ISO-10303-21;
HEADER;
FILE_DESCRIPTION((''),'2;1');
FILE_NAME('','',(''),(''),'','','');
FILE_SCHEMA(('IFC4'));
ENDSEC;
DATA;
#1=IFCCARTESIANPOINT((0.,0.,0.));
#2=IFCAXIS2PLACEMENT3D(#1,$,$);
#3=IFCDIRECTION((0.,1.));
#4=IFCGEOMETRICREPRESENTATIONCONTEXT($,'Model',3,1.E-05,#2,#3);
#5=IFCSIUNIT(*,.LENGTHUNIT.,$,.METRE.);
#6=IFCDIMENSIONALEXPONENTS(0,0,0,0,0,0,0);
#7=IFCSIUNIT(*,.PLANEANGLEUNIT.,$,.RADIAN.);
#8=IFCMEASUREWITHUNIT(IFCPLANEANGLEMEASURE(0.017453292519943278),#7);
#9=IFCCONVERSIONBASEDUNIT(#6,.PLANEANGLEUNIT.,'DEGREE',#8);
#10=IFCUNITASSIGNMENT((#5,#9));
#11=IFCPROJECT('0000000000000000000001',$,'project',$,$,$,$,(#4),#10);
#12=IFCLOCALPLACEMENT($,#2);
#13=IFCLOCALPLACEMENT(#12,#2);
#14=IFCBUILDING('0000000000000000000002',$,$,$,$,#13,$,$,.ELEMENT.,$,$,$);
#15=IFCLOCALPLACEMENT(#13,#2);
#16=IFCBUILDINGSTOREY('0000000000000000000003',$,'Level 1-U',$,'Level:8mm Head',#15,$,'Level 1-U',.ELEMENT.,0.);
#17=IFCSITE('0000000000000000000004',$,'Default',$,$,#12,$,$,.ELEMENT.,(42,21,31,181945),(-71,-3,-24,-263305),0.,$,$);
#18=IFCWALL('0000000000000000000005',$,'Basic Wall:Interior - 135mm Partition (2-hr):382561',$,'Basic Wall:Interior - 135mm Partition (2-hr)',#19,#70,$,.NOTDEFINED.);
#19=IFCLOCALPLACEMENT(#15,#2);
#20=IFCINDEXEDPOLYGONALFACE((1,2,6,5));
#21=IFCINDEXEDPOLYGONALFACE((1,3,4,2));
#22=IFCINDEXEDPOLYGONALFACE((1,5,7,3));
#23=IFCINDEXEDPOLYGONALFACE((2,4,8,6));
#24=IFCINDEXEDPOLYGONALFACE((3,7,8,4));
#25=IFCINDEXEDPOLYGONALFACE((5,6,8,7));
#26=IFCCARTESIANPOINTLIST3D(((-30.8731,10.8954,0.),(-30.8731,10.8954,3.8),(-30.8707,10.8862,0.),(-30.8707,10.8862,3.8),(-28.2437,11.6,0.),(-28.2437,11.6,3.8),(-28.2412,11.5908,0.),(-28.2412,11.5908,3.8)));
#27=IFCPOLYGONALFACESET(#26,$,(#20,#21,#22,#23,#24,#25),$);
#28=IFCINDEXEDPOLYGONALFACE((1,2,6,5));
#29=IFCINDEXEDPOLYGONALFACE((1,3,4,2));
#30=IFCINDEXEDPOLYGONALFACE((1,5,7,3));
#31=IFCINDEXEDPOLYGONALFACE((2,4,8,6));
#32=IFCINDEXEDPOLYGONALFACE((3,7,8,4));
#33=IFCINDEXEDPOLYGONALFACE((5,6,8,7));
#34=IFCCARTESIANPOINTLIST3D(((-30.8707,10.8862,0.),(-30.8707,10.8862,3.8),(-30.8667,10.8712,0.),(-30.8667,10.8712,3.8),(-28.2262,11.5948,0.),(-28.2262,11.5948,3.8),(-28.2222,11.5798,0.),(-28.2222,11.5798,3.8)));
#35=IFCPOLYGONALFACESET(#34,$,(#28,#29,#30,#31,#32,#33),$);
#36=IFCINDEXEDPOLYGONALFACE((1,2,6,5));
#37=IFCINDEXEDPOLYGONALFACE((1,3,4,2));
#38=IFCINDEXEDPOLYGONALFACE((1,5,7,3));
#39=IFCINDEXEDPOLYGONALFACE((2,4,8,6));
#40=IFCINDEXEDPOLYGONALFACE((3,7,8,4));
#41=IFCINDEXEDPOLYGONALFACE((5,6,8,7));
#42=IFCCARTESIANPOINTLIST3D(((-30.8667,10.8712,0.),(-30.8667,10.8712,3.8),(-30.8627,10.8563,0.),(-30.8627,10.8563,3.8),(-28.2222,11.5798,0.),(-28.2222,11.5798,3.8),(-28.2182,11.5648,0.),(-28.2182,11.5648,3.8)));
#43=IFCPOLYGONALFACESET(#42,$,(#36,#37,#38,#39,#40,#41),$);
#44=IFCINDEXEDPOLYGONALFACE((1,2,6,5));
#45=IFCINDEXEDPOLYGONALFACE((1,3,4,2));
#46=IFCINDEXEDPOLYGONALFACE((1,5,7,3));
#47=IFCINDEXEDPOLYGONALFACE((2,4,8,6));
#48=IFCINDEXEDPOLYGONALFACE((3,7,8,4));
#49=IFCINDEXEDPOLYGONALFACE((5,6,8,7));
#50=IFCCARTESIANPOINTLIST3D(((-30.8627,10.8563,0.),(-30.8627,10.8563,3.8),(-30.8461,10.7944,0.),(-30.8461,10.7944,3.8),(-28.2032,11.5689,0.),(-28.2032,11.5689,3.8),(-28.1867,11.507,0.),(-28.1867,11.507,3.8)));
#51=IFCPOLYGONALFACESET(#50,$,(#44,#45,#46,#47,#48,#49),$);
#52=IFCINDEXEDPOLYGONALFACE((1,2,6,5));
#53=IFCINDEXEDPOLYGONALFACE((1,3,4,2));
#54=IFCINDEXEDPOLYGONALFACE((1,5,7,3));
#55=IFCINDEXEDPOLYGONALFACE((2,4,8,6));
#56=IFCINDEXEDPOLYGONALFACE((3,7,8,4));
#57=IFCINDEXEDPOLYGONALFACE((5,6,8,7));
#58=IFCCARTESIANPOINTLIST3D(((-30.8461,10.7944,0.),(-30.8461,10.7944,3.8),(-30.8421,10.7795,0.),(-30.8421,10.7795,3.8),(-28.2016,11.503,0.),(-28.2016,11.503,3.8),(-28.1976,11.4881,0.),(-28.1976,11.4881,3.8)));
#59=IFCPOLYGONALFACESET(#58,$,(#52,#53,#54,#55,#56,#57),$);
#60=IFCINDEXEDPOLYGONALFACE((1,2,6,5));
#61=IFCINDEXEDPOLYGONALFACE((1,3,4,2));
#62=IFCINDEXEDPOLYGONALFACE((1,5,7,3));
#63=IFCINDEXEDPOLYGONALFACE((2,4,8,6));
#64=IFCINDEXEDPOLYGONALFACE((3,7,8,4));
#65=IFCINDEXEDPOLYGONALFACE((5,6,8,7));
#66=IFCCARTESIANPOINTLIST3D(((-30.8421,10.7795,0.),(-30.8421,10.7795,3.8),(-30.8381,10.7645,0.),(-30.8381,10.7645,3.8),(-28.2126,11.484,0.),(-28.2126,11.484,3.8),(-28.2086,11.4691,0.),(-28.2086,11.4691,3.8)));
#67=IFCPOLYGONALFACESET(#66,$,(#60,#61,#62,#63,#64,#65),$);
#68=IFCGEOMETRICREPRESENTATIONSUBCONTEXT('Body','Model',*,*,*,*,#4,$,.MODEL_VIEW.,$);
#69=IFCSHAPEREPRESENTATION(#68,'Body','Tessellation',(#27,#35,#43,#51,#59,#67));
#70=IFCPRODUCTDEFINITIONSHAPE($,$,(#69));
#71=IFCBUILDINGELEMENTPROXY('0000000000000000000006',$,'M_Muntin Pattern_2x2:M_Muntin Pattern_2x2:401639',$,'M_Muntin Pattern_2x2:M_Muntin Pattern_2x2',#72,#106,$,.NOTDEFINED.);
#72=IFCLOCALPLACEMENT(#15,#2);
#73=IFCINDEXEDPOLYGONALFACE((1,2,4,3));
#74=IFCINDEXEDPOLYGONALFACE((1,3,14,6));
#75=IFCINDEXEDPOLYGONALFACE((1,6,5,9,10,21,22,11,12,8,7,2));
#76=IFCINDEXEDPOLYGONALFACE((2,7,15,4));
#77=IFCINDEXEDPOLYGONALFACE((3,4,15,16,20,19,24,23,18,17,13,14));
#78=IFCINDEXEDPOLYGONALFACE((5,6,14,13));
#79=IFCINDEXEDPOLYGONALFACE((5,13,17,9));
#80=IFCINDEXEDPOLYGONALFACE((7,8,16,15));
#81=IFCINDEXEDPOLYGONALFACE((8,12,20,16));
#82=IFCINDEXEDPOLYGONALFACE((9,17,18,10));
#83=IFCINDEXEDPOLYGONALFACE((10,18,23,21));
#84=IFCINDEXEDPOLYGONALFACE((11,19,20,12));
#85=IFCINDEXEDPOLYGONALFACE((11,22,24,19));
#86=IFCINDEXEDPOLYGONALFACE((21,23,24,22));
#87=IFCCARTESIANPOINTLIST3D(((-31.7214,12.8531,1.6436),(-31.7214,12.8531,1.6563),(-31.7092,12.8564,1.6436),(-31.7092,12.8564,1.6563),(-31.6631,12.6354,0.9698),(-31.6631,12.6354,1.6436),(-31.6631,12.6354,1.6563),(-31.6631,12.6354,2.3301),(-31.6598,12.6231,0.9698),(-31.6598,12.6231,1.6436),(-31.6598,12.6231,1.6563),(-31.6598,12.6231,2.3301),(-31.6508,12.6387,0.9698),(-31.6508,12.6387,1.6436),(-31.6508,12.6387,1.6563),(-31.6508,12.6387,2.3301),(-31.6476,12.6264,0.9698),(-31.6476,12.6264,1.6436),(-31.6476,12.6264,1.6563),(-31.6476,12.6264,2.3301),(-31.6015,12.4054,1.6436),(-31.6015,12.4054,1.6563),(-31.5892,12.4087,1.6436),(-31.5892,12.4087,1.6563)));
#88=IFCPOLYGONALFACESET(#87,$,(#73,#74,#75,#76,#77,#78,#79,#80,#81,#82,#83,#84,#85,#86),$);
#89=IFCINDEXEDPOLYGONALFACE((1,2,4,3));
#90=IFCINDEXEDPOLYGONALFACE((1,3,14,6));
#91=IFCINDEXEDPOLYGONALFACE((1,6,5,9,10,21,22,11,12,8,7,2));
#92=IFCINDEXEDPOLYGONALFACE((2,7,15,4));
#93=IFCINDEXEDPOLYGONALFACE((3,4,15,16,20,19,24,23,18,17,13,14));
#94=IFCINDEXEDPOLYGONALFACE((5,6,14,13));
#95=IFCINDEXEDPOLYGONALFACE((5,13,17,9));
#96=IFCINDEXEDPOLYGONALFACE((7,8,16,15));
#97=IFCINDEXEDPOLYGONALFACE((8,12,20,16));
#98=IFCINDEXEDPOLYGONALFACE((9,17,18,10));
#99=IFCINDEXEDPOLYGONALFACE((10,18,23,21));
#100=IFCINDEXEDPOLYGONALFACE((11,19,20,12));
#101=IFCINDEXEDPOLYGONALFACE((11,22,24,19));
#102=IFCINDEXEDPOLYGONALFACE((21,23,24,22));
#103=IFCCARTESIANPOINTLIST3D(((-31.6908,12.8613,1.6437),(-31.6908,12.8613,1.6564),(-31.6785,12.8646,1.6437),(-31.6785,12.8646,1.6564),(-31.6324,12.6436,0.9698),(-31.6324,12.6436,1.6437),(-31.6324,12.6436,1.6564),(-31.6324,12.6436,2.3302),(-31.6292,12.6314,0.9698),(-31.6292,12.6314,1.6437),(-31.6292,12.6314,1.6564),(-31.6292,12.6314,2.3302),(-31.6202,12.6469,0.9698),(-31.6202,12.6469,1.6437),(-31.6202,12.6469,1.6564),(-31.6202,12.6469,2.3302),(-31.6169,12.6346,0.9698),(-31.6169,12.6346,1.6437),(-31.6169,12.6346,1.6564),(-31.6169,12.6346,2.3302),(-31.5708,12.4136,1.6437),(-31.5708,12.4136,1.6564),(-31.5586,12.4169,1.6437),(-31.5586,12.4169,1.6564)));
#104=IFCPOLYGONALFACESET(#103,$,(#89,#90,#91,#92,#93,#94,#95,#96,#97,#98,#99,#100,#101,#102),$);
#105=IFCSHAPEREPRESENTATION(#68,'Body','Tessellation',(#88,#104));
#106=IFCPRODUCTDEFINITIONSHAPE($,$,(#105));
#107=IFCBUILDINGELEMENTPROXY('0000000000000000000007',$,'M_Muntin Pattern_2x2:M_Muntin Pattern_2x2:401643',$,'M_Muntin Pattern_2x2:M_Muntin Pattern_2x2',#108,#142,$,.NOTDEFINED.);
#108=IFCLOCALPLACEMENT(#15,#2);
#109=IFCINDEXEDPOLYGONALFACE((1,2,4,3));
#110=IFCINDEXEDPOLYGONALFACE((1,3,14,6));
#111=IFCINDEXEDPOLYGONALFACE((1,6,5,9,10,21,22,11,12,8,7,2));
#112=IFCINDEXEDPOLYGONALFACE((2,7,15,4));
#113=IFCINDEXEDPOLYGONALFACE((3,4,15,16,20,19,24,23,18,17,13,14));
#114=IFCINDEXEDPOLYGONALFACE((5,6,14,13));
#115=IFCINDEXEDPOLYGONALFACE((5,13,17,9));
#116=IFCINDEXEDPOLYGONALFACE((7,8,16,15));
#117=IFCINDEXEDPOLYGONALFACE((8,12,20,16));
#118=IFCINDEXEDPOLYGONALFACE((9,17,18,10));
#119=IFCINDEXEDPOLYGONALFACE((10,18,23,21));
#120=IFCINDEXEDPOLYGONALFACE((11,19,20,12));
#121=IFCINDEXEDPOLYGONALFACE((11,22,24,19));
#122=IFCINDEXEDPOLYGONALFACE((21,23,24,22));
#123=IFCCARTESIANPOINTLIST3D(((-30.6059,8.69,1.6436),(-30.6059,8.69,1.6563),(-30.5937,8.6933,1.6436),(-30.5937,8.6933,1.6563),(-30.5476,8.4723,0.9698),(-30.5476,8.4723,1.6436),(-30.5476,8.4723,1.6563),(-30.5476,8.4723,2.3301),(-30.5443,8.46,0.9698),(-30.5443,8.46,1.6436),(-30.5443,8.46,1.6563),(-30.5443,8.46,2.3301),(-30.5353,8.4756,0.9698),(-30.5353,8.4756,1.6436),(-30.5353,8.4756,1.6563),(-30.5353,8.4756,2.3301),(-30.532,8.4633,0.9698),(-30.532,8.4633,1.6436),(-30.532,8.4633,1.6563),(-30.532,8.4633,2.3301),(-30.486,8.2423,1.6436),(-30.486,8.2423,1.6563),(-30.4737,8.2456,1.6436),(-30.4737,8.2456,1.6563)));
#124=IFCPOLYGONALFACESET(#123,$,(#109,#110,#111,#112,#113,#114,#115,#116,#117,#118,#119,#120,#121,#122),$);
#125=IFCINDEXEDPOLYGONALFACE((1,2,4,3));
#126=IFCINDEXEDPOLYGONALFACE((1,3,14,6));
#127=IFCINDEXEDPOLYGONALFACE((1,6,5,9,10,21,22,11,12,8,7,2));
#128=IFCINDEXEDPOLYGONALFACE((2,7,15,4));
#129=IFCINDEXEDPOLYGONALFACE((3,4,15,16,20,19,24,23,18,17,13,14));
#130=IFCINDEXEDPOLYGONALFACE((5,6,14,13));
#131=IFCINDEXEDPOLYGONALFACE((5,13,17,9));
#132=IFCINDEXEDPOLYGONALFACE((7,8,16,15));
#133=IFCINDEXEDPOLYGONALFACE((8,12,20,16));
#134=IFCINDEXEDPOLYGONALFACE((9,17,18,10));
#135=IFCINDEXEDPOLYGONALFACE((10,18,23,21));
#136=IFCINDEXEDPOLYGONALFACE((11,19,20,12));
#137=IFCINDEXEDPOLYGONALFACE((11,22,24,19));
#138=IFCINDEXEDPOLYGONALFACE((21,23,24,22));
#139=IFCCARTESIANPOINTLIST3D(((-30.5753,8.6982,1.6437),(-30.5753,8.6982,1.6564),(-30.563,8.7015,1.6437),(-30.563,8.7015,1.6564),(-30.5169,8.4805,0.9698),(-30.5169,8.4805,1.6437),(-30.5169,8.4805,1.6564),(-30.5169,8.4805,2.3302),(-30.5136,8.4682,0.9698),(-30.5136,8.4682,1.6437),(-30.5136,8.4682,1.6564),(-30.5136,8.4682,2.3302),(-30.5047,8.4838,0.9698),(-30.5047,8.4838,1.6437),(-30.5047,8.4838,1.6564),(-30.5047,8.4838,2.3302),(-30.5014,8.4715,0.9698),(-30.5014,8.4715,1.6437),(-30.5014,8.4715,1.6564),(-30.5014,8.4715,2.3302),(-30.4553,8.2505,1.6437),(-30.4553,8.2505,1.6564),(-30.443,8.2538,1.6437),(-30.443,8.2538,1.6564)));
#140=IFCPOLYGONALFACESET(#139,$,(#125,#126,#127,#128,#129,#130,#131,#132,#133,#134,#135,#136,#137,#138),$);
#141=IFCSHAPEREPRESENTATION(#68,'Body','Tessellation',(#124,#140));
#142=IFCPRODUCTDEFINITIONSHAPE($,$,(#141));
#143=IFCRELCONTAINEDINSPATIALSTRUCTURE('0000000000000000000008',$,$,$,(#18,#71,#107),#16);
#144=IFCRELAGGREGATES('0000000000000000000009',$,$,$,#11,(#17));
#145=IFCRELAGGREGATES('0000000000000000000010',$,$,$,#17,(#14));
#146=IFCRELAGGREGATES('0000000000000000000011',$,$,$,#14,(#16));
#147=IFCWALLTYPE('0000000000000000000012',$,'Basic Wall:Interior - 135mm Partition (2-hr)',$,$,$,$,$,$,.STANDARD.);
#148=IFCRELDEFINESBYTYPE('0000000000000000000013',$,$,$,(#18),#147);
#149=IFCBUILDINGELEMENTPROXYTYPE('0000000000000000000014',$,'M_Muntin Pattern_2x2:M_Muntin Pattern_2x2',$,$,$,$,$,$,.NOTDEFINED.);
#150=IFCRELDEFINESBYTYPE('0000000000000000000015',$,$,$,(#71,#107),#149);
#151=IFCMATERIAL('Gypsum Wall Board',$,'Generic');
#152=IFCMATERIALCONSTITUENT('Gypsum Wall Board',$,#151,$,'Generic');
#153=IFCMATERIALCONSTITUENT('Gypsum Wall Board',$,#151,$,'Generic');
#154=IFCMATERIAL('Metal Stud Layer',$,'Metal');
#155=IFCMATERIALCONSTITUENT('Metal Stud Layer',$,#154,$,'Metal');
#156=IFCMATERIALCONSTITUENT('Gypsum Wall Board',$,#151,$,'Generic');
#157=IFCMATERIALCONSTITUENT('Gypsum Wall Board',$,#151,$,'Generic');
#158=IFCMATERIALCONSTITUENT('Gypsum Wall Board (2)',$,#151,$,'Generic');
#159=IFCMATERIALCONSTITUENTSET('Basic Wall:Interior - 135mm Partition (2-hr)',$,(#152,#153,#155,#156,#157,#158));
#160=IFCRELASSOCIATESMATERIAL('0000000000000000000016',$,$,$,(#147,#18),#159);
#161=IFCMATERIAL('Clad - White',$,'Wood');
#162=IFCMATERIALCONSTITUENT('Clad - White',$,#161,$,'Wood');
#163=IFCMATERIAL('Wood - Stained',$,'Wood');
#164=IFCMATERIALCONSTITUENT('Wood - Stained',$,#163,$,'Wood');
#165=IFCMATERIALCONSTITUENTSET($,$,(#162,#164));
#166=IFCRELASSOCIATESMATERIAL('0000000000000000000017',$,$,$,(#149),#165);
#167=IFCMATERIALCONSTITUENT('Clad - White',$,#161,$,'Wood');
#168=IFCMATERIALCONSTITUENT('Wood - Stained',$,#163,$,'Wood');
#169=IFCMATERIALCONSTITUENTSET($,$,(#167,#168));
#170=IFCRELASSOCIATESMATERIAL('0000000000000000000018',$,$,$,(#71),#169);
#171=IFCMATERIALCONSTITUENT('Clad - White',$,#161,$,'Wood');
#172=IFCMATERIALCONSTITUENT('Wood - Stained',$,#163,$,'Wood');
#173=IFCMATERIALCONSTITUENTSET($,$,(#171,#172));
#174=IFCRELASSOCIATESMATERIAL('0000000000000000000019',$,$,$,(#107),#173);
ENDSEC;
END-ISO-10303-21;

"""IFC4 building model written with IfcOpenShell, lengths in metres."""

from ifc_helpers import new_model, entity, si_unit, converted_unit, direction, frame, origin, place, context, subcontext, project, spatial, indexed_curve, outline, extrude, source, transform, mapped, material, constituent, constituent_set, type_object, type_shapes, element, save


model = new_model("IFC4")

# Units and contexts
model_context = context("Model", 3, precision=1e-05, world=origin(), true_north=direction((0.0, 1.0)))
body_context = subcontext(model_context, "Body", "Model", "MODEL_VIEW")
ifc_project = project(units=[si_unit("LENGTHUNIT", "METRE"), converted_unit("PLANEANGLEUNIT", "DEGREE", entity("IfcPlaneAngleMeasure", 0.017453292519943278), si_unit("PLANEANGLEUNIT", "RADIAN"), dimensions=[0, 0, 0, 0, 0, 0, 0])], contexts=[model_context])

# Site, building, storey
site_placement = place(None, origin())
site = spatial("IfcSite", under=ifc_project, at=site_placement, Name="Default", CompositionType="ELEMENT", RefLatitude=(42, 21, 31, 181945), RefLongitude=(-71, -3, -24, -263305), RefElevation=0.0)
building_placement = place(site_placement, origin())
building = spatial("IfcBuilding", under=site, at=building_placement, CompositionType="ELEMENT")
storey_placement = place(building_placement, origin())
storey = spatial("IfcBuildingStorey", under=building, at=storey_placement, Name="Level 1-U", ObjectType="Level:8mm Head", LongName="Level 1-U", CompositionType="ELEMENT", Elevation=0.0)

# Shared definitions
ifc_material_1 = material(Name="Gypsum Wall Board", Category="Generic")
ifc_constituent_1 = constituent(ifc_material_1, Name="Gypsum Wall Board", Category="Generic")
ifc_constituent_2 = constituent(ifc_material_1, Name="Gypsum Wall Board", Category="Generic")
ifc_material_2 = material(Name="Metal Stud Layer", Category="Metal")
ifc_constituent_3 = constituent(ifc_material_2, Name="Metal Stud Layer", Category="Metal")
ifc_constituent_4 = constituent(ifc_material_1, Name="Gypsum Wall Board", Category="Generic")
ifc_constituent_5 = constituent(ifc_material_1, Name="Gypsum Wall Board", Category="Generic")
ifc_constituent_6 = constituent(ifc_material_1, Name="Gypsum Wall Board (2)", Category="Generic")
ifc_constituent_set_1 = constituent_set(constituents=[ifc_constituent_1, ifc_constituent_2, ifc_constituent_3, ifc_constituent_4, ifc_constituent_5, ifc_constituent_6], Name="Basic Wall:Interior - 135mm Partition (2-hr)")
wall_type = type_object("IfcWallType", Name="Basic Wall:Interior - 135mm Partition (2-hr)", PredefinedType="STANDARD", material=ifc_constituent_set_1)

# Wall
wall_1_placement = place(storey_placement, frame((-28.2261, 11.5345, 0.0), z_axis=(0.0, 0.0, 1.0), x_axis=(-0.965926, -0.258819, 0.0)))
element("IfcWall", 1, at=wall_1_placement, inside=storey, type_object=wall_type, material=ifc_constituent_set_1, Name="Basic Wall:Interior - 135mm Partition (2-hr):382561", ObjectType="Basic Wall:Interior - 135mm Partition (2-hr)", PredefinedType="NOTDEFINED", context=body_context, shape_type="SweptSolid", body=[
    extrude(outline(indexed_curve([(-0.0047, -1.3611), (0.0048, -1.3611), (0.0047, 1.3611), (-0.0048, 1.3611), (-0.0047, -1.3611)], self_intersect=False)), frame((1.3611, -0.063, 0.0), z_axis=(0.0, 0.0, 1.0), x_axis=(0.0, 1.0, 0.0)), (0.0, 0.0, 1.0), 3.8),
    extrude(outline(indexed_curve([(-1.3689, -0.0077), (1.3689, -0.0078), (1.3689, 0.0077), (-1.3689, 0.0078), (-1.3689, -0.0077)], self_intersect=False)), frame((1.3534, -0.0505, 0.0)), (0.0, 0.0, 1.0), 3.8),
    extrude(outline(indexed_curve([(-1.3689, -0.0077), (1.3689, -0.0078), (1.3689, 0.0077), (-1.3689, 0.0078), (-1.3689, -0.0077)], self_intersect=False)), frame((1.3534, -0.035, 0.0)), (0.0, 0.0, 1.0), 3.8),
    extrude(outline(indexed_curve([(-1.3766, -0.032), (1.3766, -0.032), (1.3766, 0.032), (-1.3766, 0.032), (-1.3766, -0.032)], self_intersect=False)), frame((1.3456, 0.0048, 0.0)), (0.0, 0.0, 1.0), 3.8),
    extrude(outline(indexed_curve([(-1.3689, -0.0077), (1.3689, -0.0078), (1.3689, 0.0077), (-1.3689, 0.0078), (-1.3689, -0.0077)], self_intersect=False)), frame((1.3534, 0.0445, 0.0)), (0.0, 0.0, 1.0), 3.8),
    extrude(outline(indexed_curve([(-0.0078, -1.3611), (0.0077, -1.3611), (0.0078, 1.3611), (-0.0077, 1.3611), (-0.0078, -1.3611)], self_intersect=False)), frame((1.3611, 0.06, 0.0), z_axis=(0.0, 0.0, 1.0), x_axis=(0.0, -1.0, 0.0)), (0.0, 0.0, 1.0), 3.8),
])

# Building element proxies
ifc_material_3 = material(Name="Clad - White", Category="Wood")
ifc_constituent_7 = constituent(ifc_material_3, Name="Clad - White", Category="Wood")
ifc_material_4 = material(Name="Wood - Stained", Category="Wood")
ifc_constituent_8 = constituent(ifc_material_4, Name="Wood - Stained", Category="Wood")
ifc_constituent_set_2 = constituent_set(constituents=[ifc_constituent_7, ifc_constituent_8])
ifc_constituent_9 = constituent(ifc_material_3, Name="Clad - White", Category="Wood")
ifc_constituent_10 = constituent(ifc_material_4, Name="Wood - Stained", Category="Wood")
ifc_constituent_set_3 = constituent_set(constituents=[ifc_constituent_9, ifc_constituent_10])
building_element_proxy_type_1 = type_object("IfcBuildingElementProxyType", Name="M_Muntin Pattern_2x2:M_Muntin Pattern_2x2", PredefinedType="NOTDEFINED", material=ifc_constituent_set_3)
shared_shape_1 = source(origin(), body_context, "Body", "SweptSolid", [
    extrude(outline(indexed_curve([(0.0064, -0.0064), (0.6801, -0.0064), (0.6801, 0.0063), (0.0064, 0.0063), (0.0064, 0.2317), (-0.0063, 0.2317), (-0.0063, 0.0063), (-0.6802, 0.0063), (-0.6802, -0.0064), (-0.0063, -0.0064), (-0.0063, -0.2317), (0.0064, -0.2317), (0.0064, -0.0064)], self_intersect=False)), frame((0.0, 0.0095, 0.6801), z_axis=(0.0, 1.0, 0.0), x_axis=(0.0, 0.0, 1.0)), (0.0, 0.0, 1.0), 0.0127),
    extrude(outline(indexed_curve([(0.0064, -0.0064), (0.6802, -0.0064), (0.6802, 0.0063), (0.0064, 0.0063), (0.0064, 0.2317), (-0.0063, 0.2317), (-0.0063, 0.0063), (-0.6802, 0.0063), (-0.6802, -0.0064), (-0.0063, -0.0064), (-0.0063, -0.2317), (0.0064, -0.2317), (0.0064, -0.0064)], self_intersect=False)), frame((0.0, -0.0222, 0.6802), z_axis=(0.0, 1.0, 0.0), x_axis=(0.0, 0.0, 1.0)), (0.0, 0.0, 1.0), 0.0127),
])
type_shapes(building_element_proxy_type_1, [shared_shape_1])
proxy_1_placement = place(storey_placement, frame((-31.64, 12.635, 0.9698), z_axis=(0.0, 0.0, 1.0), x_axis=(-0.258819, 0.965926, 0.0)))
element("IfcBuildingElementProxy", 2, at=proxy_1_placement, inside=storey, type_object=building_element_proxy_type_1, material=ifc_constituent_set_2, Name="M_Muntin Pattern_2x2:M_Muntin Pattern_2x2:401639", ObjectType="M_Muntin Pattern_2x2:M_Muntin Pattern_2x2", PredefinedType="NOTDEFINED", context=body_context, shape_type="MappedRepresentation", body=[
    mapped(shared_shape_1, transform((0.0, 0.0, 0.0), scale=1.0)),
])
ifc_constituent_11 = constituent(ifc_material_3, Name="Clad - White", Category="Wood")
ifc_constituent_12 = constituent(ifc_material_4, Name="Wood - Stained", Category="Wood")
ifc_constituent_set_4 = constituent_set(constituents=[ifc_constituent_11, ifc_constituent_12])
proxy_2_placement = place(storey_placement, frame((-30.5245, 8.4719, 0.9698), z_axis=(0.0, 0.0, 1.0), x_axis=(-0.258819, 0.965926, 0.0)))
element("IfcBuildingElementProxy", 3, at=proxy_2_placement, inside=storey, type_object=building_element_proxy_type_1, material=ifc_constituent_set_4, Name="M_Muntin Pattern_2x2:M_Muntin Pattern_2x2:401643", ObjectType="M_Muntin Pattern_2x2:M_Muntin Pattern_2x2", PredefinedType="NOTDEFINED", context=body_context, shape_type="MappedRepresentation", body=[
    mapped(shared_shape_1, transform((0.0, 0.0, 0.0), scale=1.0)),
])

save(model, "model.ifc")
